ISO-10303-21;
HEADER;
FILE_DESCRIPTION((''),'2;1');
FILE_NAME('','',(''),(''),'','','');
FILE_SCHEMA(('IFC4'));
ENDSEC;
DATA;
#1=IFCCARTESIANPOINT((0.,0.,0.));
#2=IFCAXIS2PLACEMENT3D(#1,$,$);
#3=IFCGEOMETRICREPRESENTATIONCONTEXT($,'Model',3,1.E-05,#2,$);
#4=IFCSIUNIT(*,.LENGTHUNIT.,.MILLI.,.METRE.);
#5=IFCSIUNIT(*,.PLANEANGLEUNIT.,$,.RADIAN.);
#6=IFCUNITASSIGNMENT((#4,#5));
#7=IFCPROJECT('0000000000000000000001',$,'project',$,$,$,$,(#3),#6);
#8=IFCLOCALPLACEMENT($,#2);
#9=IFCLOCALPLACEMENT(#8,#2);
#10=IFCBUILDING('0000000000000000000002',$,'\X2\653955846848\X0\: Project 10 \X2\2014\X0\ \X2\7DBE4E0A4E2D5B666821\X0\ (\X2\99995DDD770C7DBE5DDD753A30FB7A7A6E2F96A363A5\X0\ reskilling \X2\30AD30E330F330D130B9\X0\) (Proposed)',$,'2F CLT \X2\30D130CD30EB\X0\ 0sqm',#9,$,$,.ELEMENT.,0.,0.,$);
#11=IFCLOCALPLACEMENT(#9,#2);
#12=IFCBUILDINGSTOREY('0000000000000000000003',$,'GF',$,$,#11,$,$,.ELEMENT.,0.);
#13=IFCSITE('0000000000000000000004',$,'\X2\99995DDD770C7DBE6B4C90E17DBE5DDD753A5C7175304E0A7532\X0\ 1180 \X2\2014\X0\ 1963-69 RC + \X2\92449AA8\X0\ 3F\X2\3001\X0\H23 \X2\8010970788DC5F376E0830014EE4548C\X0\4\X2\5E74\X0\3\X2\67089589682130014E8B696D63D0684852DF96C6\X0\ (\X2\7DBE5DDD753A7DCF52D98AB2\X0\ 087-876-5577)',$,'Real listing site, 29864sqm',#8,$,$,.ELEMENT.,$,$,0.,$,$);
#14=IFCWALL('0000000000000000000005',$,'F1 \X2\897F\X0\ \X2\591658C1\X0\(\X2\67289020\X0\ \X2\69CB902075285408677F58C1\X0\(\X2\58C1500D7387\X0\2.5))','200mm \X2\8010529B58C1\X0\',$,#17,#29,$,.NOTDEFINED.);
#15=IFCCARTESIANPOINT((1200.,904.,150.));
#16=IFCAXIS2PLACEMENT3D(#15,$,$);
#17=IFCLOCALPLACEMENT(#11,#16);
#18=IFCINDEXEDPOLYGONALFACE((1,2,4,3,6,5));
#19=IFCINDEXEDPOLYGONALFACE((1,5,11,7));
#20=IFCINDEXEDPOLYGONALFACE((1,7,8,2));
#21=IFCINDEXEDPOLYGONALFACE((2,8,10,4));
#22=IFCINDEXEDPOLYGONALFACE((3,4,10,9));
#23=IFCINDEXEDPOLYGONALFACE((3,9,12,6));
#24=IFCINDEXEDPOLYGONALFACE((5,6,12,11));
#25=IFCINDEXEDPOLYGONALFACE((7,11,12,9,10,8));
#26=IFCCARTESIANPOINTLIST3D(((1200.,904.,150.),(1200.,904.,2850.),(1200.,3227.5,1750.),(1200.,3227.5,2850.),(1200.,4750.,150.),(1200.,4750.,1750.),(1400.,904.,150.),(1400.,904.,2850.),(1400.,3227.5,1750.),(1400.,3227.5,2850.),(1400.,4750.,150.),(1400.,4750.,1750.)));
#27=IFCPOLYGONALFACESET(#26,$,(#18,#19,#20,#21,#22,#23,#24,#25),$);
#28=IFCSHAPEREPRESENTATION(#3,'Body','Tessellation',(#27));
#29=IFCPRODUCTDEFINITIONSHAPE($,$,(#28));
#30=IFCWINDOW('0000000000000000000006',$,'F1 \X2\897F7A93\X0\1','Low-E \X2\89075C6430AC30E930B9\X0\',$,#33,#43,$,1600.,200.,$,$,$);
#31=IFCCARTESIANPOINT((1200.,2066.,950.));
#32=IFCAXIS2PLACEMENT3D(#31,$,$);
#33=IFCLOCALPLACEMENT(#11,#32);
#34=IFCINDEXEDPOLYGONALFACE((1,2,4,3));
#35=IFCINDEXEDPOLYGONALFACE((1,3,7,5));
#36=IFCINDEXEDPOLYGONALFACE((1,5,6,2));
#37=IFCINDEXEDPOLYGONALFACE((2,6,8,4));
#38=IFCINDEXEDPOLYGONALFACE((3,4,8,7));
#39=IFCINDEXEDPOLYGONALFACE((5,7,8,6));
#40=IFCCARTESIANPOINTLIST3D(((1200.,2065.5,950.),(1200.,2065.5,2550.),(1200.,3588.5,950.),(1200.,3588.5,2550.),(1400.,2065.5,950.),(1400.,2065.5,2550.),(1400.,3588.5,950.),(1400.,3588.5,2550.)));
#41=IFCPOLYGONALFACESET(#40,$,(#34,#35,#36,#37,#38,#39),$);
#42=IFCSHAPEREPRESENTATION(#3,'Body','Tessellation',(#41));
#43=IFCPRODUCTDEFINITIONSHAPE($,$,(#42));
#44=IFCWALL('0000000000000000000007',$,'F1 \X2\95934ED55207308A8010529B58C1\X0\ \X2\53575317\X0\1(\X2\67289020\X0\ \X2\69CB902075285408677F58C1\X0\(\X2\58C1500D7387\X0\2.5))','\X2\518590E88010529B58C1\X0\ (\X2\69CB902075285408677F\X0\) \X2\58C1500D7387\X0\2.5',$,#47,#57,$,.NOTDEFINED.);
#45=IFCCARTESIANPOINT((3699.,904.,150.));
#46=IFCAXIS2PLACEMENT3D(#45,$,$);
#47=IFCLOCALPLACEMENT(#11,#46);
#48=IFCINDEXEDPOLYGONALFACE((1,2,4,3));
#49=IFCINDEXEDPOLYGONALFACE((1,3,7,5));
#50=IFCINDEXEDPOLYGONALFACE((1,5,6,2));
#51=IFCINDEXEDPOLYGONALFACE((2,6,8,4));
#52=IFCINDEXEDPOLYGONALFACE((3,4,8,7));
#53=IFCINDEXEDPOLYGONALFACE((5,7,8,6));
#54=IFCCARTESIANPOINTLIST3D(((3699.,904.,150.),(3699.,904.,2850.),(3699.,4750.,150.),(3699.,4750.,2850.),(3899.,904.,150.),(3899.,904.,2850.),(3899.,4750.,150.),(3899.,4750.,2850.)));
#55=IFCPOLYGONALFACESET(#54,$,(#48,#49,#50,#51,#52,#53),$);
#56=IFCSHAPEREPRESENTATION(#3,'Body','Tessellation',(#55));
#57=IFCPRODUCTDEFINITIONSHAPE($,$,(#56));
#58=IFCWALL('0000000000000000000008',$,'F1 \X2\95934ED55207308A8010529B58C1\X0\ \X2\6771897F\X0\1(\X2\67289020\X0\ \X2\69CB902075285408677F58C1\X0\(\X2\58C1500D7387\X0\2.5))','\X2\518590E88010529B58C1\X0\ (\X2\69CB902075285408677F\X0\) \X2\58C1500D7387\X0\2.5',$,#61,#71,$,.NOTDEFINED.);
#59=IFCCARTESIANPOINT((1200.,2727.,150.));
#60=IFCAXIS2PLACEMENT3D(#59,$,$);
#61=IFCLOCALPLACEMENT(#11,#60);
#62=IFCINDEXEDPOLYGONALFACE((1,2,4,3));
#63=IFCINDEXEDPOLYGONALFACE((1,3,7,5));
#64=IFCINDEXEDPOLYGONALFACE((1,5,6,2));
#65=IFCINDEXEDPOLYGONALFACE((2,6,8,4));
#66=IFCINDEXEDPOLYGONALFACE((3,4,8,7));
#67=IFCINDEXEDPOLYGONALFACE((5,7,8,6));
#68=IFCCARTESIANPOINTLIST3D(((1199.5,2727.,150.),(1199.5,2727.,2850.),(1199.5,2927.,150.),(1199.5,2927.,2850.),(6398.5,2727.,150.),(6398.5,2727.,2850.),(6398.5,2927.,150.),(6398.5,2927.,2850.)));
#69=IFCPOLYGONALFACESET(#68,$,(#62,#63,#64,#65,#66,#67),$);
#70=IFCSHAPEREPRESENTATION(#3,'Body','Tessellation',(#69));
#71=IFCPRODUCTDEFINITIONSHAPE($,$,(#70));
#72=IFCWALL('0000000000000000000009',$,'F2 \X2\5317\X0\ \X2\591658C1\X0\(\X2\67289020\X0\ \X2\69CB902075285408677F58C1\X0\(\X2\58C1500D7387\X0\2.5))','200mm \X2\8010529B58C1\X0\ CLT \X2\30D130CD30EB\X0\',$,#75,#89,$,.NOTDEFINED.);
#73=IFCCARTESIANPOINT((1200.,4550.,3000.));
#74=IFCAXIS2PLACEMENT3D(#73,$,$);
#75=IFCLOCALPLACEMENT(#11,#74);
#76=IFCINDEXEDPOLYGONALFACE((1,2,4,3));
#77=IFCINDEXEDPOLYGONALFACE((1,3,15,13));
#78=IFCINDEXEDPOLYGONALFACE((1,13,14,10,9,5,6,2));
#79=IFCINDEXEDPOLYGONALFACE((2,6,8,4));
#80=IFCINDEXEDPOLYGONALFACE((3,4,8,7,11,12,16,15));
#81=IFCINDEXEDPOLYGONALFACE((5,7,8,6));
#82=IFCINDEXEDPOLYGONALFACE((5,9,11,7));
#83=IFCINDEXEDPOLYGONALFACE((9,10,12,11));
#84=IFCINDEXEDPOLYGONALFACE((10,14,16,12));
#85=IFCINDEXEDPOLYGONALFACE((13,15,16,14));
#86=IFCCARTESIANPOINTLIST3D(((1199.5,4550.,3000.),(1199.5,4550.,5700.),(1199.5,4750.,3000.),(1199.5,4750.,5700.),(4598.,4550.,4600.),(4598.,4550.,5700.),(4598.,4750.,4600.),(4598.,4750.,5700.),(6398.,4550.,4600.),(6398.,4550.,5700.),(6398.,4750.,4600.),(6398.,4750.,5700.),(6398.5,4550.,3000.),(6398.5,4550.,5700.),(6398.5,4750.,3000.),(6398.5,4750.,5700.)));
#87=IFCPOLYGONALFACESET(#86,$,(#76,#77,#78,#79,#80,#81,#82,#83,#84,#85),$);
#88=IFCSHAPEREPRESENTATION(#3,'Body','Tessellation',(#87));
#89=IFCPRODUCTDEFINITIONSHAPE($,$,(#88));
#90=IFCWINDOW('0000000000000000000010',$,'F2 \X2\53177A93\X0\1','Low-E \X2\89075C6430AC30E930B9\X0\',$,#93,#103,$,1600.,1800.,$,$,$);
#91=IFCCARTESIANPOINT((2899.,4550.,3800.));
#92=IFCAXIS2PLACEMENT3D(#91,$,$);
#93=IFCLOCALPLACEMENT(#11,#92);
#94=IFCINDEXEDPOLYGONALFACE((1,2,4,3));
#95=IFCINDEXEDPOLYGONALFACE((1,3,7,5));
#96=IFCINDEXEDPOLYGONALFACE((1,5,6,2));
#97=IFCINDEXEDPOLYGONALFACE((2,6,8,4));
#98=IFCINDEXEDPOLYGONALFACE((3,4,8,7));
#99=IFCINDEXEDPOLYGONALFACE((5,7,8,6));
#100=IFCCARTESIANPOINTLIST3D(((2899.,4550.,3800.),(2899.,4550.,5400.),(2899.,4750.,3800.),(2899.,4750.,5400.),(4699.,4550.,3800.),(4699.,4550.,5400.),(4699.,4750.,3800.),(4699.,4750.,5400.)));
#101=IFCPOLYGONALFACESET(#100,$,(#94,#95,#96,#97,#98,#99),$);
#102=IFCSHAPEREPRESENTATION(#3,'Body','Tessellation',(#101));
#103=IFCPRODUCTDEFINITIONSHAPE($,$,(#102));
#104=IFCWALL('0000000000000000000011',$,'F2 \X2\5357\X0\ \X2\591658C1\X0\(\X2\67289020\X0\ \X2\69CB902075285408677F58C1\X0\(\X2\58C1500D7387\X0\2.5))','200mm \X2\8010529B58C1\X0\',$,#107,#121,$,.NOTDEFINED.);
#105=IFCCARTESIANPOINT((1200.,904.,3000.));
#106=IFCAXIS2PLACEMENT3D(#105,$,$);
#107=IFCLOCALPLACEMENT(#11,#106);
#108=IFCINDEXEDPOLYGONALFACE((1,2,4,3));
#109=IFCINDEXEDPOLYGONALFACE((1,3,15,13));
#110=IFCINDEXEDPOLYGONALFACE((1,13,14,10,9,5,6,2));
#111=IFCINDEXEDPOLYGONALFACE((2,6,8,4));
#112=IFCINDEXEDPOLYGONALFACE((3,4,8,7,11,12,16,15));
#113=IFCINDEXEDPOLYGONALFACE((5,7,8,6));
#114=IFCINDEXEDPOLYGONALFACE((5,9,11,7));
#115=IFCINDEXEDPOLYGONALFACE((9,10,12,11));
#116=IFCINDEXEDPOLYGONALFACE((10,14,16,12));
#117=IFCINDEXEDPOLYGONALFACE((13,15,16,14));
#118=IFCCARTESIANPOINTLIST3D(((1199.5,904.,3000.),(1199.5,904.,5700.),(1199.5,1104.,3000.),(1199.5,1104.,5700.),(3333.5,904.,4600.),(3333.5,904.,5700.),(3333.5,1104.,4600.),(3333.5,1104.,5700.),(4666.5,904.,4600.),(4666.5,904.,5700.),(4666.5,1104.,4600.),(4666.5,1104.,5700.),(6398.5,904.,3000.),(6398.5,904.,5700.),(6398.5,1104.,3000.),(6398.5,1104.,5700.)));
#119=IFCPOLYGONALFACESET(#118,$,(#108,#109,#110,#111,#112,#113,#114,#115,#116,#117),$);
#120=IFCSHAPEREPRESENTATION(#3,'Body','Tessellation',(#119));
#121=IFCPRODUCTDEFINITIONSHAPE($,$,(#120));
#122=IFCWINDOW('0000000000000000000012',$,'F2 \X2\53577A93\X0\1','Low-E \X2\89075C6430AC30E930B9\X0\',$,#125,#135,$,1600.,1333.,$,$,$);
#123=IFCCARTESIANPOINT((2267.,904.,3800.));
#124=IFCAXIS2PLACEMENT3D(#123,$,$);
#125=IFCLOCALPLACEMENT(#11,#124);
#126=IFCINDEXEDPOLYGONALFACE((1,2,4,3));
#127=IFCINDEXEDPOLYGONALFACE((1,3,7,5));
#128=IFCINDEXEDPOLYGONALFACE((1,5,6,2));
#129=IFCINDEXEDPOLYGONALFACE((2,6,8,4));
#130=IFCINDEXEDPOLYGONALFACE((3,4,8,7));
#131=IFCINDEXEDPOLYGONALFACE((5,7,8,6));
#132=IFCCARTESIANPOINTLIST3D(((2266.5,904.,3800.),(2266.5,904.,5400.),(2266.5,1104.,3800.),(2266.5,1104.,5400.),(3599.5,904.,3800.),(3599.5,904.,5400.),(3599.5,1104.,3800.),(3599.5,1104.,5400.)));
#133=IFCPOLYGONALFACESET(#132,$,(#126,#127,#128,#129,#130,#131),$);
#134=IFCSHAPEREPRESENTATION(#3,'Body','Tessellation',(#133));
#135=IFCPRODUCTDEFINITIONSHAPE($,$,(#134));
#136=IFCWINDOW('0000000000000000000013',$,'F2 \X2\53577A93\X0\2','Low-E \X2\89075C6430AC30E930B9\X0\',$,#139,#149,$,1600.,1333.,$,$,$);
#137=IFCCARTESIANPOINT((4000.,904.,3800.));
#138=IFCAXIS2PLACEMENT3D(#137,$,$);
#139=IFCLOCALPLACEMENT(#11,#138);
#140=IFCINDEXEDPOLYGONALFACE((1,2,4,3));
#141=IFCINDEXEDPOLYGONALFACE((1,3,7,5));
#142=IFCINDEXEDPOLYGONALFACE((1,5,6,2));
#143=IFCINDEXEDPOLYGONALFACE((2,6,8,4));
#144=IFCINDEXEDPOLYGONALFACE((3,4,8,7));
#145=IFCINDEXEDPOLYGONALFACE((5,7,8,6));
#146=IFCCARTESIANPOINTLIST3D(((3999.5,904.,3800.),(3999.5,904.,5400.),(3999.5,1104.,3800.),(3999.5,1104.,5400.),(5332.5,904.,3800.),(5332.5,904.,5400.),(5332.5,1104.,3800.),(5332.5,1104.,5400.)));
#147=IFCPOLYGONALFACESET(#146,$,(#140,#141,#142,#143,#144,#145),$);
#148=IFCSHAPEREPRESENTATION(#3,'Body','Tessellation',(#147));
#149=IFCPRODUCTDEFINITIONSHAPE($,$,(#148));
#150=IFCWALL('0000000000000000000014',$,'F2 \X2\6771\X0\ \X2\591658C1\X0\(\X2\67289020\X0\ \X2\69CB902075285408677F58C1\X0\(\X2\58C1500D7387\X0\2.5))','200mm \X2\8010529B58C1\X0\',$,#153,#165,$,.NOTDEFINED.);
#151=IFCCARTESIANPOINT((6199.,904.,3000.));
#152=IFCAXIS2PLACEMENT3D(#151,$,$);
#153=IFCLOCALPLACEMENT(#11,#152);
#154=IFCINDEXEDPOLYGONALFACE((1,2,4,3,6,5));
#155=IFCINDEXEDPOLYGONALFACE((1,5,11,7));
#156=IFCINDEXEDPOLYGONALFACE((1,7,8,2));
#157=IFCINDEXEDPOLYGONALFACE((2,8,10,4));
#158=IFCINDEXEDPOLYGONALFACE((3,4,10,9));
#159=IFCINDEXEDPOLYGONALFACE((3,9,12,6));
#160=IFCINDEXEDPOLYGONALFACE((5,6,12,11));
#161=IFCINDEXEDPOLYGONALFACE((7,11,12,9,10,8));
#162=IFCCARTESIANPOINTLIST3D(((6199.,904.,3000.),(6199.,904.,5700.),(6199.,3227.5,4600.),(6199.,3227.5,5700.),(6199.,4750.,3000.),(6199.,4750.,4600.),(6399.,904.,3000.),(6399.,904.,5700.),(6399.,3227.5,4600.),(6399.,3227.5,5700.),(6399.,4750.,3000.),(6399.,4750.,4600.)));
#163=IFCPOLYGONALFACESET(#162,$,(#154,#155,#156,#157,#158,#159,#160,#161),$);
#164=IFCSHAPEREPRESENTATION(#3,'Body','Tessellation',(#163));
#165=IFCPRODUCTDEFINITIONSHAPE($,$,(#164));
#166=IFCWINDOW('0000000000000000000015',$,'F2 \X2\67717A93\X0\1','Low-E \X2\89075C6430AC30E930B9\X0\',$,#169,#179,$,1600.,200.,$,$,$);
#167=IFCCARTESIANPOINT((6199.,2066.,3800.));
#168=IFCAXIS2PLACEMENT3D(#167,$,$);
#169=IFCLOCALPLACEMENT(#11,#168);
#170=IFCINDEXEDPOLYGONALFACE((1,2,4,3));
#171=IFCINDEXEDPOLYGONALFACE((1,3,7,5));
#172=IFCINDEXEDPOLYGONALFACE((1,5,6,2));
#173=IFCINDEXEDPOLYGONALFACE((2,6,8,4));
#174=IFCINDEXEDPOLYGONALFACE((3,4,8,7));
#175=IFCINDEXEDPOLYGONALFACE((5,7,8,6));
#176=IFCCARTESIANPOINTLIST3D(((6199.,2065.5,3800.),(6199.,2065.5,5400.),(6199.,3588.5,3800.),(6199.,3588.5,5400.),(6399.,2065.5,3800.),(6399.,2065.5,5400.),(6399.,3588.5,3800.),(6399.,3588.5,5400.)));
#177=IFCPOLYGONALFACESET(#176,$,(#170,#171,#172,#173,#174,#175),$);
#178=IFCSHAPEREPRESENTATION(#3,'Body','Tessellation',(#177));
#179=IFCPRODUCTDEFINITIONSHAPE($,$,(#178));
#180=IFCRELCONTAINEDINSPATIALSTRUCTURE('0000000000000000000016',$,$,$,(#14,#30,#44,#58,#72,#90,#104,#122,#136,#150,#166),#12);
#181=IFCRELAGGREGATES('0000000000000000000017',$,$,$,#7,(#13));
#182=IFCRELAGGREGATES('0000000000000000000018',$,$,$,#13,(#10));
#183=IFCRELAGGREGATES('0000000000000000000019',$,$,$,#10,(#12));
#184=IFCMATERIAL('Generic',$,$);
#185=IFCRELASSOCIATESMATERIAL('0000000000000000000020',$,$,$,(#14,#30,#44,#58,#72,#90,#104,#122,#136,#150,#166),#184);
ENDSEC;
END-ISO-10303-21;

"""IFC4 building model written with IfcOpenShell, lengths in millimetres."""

from ifc_helpers import new_model, si_unit, frame, frame_2d, origin, place, context, project, spatial, rectangle, extrude, material, element, fill, save


model = new_model("IFC4")

# Units and contexts
model_context = context("Model", 3, precision=1e-05, world=origin())
ifc_project = project(units=[si_unit("LENGTHUNIT", "METRE", prefix="MILLI"), si_unit("PLANEANGLEUNIT", "RADIAN")], contexts=[model_context])

# Site, building, storey
site_placement = place(None, origin())
site = spatial("IfcSite", under=ifc_project, at=site_placement, Name="香川県綾歌郡綾川町山田上甲 1180 — 1963-69 RC + 鉄骨 3F、H23 耐震補強済、令和4年3月閉校、事業提案募集 (綾川町総務課 087-876-5577)", ObjectType="Real listing site, 29864sqm", CompositionType="ELEMENT", RefElevation=0.0)
building_placement = place(site_placement, origin())
building = spatial("IfcBuilding", under=site, at=building_placement, Name="改善案: Project 10 — 綾上中学校 (香川県綾川町・空港隣接 reskilling キャンパス) (Proposed)", ObjectType="2F CLT パネル 0sqm", CompositionType="ELEMENT", ElevationOfRefHeight=0.0, ElevationOfTerrain=0.0)
storey_placement = place(building_placement, origin())
storey = spatial("IfcBuildingStorey", under=building, at=storey_placement, Name="GF", CompositionType="ELEMENT", Elevation=0.0)

# Shared definitions
ifc_material_1 = material(Name="Generic")

# Wall, opening, window
wall_1_placement = place(storey_placement, frame((1200.0, 904.0, 150.0)))
wall_1 = element("IfcWall", 1, at=wall_1_placement, inside=storey, material=ifc_material_1, Name="F1 西 外壁(木造 構造用合板壁(壁倍率2.5))", Description="200mm 耐力壁", PredefinedType="NOTDEFINED", context=model_context, shape_type="SweptSolid", body=[
    extrude(rectangle(XDim=200.0, YDim=3846.0, at=frame_2d((100.0, 1923.0))), frame((1200.0, 904.0, 150.0)), (0.0, 0.0, 1.0), 2700.0),
])
opening_1_placement = place(storey_placement, frame((1200.0, 2066.0, 950.0)))
opening_1 = element("IfcOpeningElement", 2, at=opening_1_placement, cuts=wall_1, PredefinedType="NOTDEFINED", context=model_context, shape_type="SweptSolid", body=[
    extrude(rectangle(XDim=200.0, YDim=1523.0, at=frame_2d((100.0, 761.0))), frame((1200.0, 2066.0, 950.0)), (0.0, 0.0, 1.0), 1600.0),
])
window_1_placement = place(storey_placement, frame((1200.0, 2066.0, 950.0)))
window_1 = element("IfcWindow", 3, at=window_1_placement, inside=storey, material=ifc_material_1, Name="F1 西窓1", Description="Low-E 複層ガラス", OverallHeight=1600.0, OverallWidth=200.0, context=model_context, shape_type="SweptSolid", body=[
    extrude(rectangle(XDim=200.0, YDim=1523.0, at=frame_2d((100.0, 761.0))), frame((1200.0, 2066.0, 950.0)), (0.0, 0.0, 1.0), 1600.0),
])
fill(opening_1, window_1)

# Walls
wall_2_placement = place(storey_placement, frame((3699.0, 904.0, 150.0)))
element("IfcWall", 4, at=wall_2_placement, inside=storey, material=ifc_material_1, Name="F1 間仕切り耐力壁 南北1(木造 構造用合板壁(壁倍率2.5))", Description="内部耐力壁 (構造用合板) 壁倍率2.5", PredefinedType="NOTDEFINED", context=model_context, shape_type="SweptSolid", body=[
    extrude(rectangle(XDim=200.0, YDim=3846.0, at=frame_2d((100.0, 1923.0))), frame((3699.0, 904.0, 150.0)), (0.0, 0.0, 1.0), 2700.0),
])
wall_3_placement = place(storey_placement, frame((1200.0, 2727.0, 150.0)))
element("IfcWall", 5, at=wall_3_placement, inside=storey, material=ifc_material_1, Name="F1 間仕切り耐力壁 東西1(木造 構造用合板壁(壁倍率2.5))", Description="内部耐力壁 (構造用合板) 壁倍率2.5", PredefinedType="NOTDEFINED", context=model_context, shape_type="SweptSolid", body=[
    extrude(rectangle(XDim=5199.0, YDim=200.0, at=frame_2d((2599.0, 100.0))), frame((1200.0, 2727.0, 150.0)), (0.0, 0.0, 1.0), 2700.0),
])

# Wall, opening, window
wall_4_placement = place(storey_placement, frame((1200.0, 4550.0, 3000.0)))
wall_4 = element("IfcWall", 6, at=wall_4_placement, inside=storey, material=ifc_material_1, Name="F2 北 外壁(木造 構造用合板壁(壁倍率2.5))", Description="200mm 耐力壁 CLT パネル", PredefinedType="NOTDEFINED", context=model_context, shape_type="SweptSolid", body=[
    extrude(rectangle(XDim=5199.0, YDim=200.0, at=frame_2d((2599.0, 100.0))), frame((1200.0, 4550.0, 3000.0)), (0.0, 0.0, 1.0), 2700.0),
])
opening_2_placement = place(storey_placement, frame((2899.0, 4550.0, 3800.0)))
opening_2 = element("IfcOpeningElement", 7, at=opening_2_placement, cuts=wall_4, PredefinedType="NOTDEFINED", context=model_context, shape_type="SweptSolid", body=[
    extrude(rectangle(XDim=1800.0, YDim=200.0, at=frame_2d((900.0, 100.0))), frame((2899.0, 4550.0, 3800.0)), (0.0, 0.0, 1.0), 1600.0),
])
window_2_placement = place(storey_placement, frame((2899.0, 4550.0, 3800.0)))
window_2 = element("IfcWindow", 8, at=window_2_placement, inside=storey, material=ifc_material_1, Name="F2 北窓1", Description="Low-E 複層ガラス", OverallHeight=1600.0, OverallWidth=1800.0, context=model_context, shape_type="SweptSolid", body=[
    extrude(rectangle(XDim=1800.0, YDim=200.0, at=frame_2d((900.0, 100.0))), frame((2899.0, 4550.0, 3800.0)), (0.0, 0.0, 1.0), 1600.0),
])
fill(opening_2, window_2)

# Wall, openings, windows
wall_5_placement = place(storey_placement, frame((1200.0, 904.0, 3000.0)))
wall_5 = element("IfcWall", 9, at=wall_5_placement, inside=storey, material=ifc_material_1, Name="F2 南 外壁(木造 構造用合板壁(壁倍率2.5))", Description="200mm 耐力壁", PredefinedType="NOTDEFINED", context=model_context, shape_type="SweptSolid", body=[
    extrude(rectangle(XDim=5199.0, YDim=200.0, at=frame_2d((2599.0, 100.0))), frame((1200.0, 904.0, 3000.0)), (0.0, 0.0, 1.0), 2700.0),
])
opening_3_placement = place(storey_placement, frame((2267.0, 904.0, 3800.0)))
opening_3 = element("IfcOpeningElement", 10, at=opening_3_placement, cuts=wall_5, PredefinedType="NOTDEFINED", context=model_context, shape_type="SweptSolid", body=[
    extrude(rectangle(XDim=1333.0, YDim=200.0, at=frame_2d((666.0, 100.0))), frame((2267.0, 904.0, 3800.0)), (0.0, 0.0, 1.0), 1600.0),
])
opening_4_placement = place(storey_placement, frame((4000.0, 904.0, 3800.0)))
opening_4 = element("IfcOpeningElement", 11, at=opening_4_placement, cuts=wall_5, PredefinedType="NOTDEFINED", context=model_context, shape_type="SweptSolid", body=[
    extrude(rectangle(XDim=1333.0, YDim=200.0, at=frame_2d((666.0, 100.0))), frame((4000.0, 904.0, 3800.0)), (0.0, 0.0, 1.0), 1600.0),
])
window_3_placement = place(storey_placement, frame((2267.0, 904.0, 3800.0)))
window_3 = element("IfcWindow", 12, at=window_3_placement, inside=storey, material=ifc_material_1, Name="F2 南窓1", Description="Low-E 複層ガラス", OverallHeight=1600.0, OverallWidth=1333.0, context=model_context, shape_type="SweptSolid", body=[
    extrude(rectangle(XDim=1333.0, YDim=200.0, at=frame_2d((666.0, 100.0))), frame((2267.0, 904.0, 3800.0)), (0.0, 0.0, 1.0), 1600.0),
])
fill(opening_3, window_3)
window_4_placement = place(storey_placement, frame((4000.0, 904.0, 3800.0)))
window_4 = element("IfcWindow", 13, at=window_4_placement, inside=storey, material=ifc_material_1, Name="F2 南窓2", Description="Low-E 複層ガラス", OverallHeight=1600.0, OverallWidth=1333.0, context=model_context, shape_type="SweptSolid", body=[
    extrude(rectangle(XDim=1333.0, YDim=200.0, at=frame_2d((666.0, 100.0))), frame((4000.0, 904.0, 3800.0)), (0.0, 0.0, 1.0), 1600.0),
])
fill(opening_4, window_4)

# Wall, opening, window
wall_6_placement = place(storey_placement, frame((6199.0, 904.0, 3000.0)))
wall_6 = element("IfcWall", 14, at=wall_6_placement, inside=storey, material=ifc_material_1, Name="F2 東 外壁(木造 構造用合板壁(壁倍率2.5))", Description="200mm 耐力壁", PredefinedType="NOTDEFINED", context=model_context, shape_type="SweptSolid", body=[
    extrude(rectangle(XDim=200.0, YDim=3846.0, at=frame_2d((100.0, 1923.0))), frame((6199.0, 904.0, 3000.0)), (0.0, 0.0, 1.0), 2700.0),
])
opening_5_placement = place(storey_placement, frame((6199.0, 2066.0, 3800.0)))
opening_5 = element("IfcOpeningElement", 15, at=opening_5_placement, cuts=wall_6, PredefinedType="NOTDEFINED", context=model_context, shape_type="SweptSolid", body=[
    extrude(rectangle(XDim=200.0, YDim=1523.0, at=frame_2d((100.0, 761.0))), frame((6199.0, 2066.0, 3800.0)), (0.0, 0.0, 1.0), 1600.0),
])
window_5_placement = place(storey_placement, frame((6199.0, 2066.0, 3800.0)))
window_5 = element("IfcWindow", 16, at=window_5_placement, inside=storey, material=ifc_material_1, Name="F2 東窓1", Description="Low-E 複層ガラス", OverallHeight=1600.0, OverallWidth=200.0, context=model_context, shape_type="SweptSolid", body=[
    extrude(rectangle(XDim=200.0, YDim=1523.0, at=frame_2d((100.0, 761.0))), frame((6199.0, 2066.0, 3800.0)), (0.0, 0.0, 1.0), 1600.0),
])
fill(opening_5, window_5)

save(model, "model.ifc")
